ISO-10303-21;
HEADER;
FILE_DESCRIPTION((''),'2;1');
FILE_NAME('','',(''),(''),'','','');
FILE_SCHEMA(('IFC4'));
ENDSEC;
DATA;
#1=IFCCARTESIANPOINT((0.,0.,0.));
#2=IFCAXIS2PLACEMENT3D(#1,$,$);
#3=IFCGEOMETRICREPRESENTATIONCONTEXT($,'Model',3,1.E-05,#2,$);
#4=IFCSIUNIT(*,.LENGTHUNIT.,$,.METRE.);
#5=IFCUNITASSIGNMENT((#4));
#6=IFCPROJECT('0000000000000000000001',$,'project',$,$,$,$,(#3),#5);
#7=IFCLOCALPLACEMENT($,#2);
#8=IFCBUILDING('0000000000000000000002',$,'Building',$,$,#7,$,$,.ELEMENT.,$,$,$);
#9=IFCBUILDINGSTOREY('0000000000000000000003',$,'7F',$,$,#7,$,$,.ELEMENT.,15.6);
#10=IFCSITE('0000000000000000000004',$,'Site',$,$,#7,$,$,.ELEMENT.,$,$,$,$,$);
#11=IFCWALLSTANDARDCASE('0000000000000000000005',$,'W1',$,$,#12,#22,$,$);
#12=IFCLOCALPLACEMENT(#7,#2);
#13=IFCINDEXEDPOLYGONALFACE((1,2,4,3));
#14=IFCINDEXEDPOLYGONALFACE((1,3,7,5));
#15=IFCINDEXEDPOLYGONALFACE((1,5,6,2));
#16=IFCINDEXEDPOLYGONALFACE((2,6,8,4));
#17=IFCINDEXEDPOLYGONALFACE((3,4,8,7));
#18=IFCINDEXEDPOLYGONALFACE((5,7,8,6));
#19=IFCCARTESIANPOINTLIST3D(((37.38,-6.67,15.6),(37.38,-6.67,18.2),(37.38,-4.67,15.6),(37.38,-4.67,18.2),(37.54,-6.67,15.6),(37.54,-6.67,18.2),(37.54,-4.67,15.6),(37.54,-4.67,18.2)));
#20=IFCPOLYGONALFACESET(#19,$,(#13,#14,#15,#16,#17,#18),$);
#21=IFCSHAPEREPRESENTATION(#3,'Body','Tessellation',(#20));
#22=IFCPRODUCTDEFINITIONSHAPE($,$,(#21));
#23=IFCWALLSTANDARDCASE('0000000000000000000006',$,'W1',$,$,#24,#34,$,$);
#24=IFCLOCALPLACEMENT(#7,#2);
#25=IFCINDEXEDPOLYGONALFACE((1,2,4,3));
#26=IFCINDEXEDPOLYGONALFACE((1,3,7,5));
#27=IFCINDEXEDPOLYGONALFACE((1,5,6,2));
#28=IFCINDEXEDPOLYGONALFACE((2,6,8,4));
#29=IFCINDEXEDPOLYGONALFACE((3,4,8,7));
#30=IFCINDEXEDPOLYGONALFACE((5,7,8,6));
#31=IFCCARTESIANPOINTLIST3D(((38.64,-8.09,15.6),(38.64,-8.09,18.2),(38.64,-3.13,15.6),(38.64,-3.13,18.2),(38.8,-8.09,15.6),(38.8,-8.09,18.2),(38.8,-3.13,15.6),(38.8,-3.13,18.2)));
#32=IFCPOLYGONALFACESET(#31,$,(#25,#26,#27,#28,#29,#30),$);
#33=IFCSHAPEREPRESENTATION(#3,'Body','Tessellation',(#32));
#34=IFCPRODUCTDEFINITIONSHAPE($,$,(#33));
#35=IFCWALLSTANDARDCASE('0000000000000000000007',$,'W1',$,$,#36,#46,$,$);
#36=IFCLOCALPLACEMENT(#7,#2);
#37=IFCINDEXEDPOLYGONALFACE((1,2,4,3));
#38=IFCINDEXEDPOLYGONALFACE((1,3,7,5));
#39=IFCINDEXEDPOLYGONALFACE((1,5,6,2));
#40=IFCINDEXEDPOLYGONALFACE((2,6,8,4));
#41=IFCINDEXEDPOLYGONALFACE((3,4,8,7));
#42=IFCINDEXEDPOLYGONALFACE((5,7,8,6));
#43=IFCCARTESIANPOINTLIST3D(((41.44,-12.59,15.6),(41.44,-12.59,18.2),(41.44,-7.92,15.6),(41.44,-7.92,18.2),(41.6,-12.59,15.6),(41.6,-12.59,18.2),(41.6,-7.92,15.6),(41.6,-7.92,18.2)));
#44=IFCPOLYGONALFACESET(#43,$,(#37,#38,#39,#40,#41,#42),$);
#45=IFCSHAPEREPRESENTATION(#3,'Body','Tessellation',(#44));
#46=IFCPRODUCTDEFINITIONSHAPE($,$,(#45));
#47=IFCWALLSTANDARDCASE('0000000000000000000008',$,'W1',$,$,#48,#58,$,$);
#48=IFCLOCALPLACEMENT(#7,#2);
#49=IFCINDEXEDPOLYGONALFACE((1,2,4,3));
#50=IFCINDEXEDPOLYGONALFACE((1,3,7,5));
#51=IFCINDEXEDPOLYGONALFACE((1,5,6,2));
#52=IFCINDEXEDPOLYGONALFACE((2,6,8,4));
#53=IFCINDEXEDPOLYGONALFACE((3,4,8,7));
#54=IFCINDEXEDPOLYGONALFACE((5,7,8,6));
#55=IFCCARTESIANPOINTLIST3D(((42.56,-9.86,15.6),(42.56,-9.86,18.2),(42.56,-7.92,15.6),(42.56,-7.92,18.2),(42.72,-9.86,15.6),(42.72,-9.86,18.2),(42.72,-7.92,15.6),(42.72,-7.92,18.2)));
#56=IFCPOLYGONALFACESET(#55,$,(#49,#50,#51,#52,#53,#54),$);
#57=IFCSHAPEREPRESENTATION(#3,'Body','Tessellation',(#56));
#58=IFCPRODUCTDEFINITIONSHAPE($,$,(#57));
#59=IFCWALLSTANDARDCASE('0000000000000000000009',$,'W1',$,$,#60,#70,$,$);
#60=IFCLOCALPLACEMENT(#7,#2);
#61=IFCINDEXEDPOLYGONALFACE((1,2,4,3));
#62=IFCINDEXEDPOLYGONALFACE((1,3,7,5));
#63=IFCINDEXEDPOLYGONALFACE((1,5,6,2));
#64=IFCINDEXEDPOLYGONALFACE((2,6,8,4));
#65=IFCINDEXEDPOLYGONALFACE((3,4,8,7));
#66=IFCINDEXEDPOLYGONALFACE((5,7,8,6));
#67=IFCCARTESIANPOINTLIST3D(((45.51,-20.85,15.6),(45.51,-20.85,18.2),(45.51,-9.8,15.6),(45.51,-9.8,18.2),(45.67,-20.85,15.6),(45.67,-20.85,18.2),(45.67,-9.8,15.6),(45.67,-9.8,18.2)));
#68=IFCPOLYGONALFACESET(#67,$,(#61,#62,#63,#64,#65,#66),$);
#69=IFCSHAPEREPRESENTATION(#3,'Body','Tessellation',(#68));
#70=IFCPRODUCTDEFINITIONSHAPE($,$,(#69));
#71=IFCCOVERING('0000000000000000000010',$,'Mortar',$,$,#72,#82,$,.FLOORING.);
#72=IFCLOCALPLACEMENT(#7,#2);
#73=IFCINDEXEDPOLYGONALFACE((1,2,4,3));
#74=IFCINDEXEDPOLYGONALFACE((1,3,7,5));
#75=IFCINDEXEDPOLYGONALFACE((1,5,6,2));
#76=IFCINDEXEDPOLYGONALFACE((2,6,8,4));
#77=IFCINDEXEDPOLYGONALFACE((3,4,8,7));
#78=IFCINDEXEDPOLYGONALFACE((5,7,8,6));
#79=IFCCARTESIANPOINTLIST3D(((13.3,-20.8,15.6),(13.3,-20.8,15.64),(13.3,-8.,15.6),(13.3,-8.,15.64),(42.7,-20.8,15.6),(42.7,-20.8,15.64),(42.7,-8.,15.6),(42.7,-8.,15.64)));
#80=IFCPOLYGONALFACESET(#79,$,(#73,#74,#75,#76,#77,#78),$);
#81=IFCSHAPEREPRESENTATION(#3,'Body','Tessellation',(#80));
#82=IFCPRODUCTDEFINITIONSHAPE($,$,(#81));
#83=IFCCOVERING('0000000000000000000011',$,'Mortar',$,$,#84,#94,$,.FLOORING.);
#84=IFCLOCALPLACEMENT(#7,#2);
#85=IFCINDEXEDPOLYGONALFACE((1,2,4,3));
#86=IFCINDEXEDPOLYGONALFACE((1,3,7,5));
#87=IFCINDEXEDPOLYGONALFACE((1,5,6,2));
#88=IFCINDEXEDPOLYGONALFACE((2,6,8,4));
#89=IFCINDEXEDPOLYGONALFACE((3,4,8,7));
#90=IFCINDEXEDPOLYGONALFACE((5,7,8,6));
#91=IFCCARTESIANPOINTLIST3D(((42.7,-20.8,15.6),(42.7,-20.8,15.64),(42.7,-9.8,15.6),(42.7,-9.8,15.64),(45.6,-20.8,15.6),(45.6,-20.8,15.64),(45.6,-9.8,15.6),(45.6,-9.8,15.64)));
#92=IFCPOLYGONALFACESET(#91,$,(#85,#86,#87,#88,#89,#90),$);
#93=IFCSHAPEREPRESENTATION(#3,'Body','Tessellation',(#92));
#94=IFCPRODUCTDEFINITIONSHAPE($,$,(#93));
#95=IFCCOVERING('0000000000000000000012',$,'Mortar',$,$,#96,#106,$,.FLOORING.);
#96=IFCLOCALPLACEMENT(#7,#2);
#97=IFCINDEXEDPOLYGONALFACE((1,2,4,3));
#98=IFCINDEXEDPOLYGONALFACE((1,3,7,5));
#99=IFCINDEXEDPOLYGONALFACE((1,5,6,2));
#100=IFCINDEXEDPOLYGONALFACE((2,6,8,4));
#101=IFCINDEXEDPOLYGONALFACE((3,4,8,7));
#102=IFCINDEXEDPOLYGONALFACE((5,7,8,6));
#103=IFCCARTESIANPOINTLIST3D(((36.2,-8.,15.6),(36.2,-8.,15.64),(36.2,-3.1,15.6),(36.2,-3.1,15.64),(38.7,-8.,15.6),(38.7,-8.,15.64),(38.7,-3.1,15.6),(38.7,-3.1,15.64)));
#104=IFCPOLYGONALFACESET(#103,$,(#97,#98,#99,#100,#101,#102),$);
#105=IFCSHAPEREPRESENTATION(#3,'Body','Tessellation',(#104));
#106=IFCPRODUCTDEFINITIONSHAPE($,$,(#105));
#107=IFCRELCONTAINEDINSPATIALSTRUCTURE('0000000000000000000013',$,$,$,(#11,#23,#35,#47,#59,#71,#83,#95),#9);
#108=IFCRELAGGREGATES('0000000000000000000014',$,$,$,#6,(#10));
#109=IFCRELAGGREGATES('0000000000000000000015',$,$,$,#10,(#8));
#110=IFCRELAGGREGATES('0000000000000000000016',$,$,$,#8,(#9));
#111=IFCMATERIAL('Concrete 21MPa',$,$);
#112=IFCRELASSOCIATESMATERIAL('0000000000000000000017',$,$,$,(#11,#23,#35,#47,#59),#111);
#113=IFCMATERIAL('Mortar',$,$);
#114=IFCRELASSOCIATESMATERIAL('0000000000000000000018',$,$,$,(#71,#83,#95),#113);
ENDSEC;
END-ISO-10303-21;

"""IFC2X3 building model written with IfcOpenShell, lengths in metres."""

from ifc_helpers import new_model, si_unit, frame, origin, origin_2d, place, context, project, spatial, rectangle, extrude, material, element, save


model = new_model("IFC2X3")

# Units and contexts
model_context = context("Model", 3, precision=1e-05, world=origin())
ifc_project = project(units=[si_unit("LENGTHUNIT", "METRE")], contexts=[model_context])

# Site, building, storey
placement = place(None, origin())
site = spatial("IfcSite", under=ifc_project, at=placement, Name="Site", CompositionType="ELEMENT")
building = spatial("IfcBuilding", under=site, at=placement, Name="Building", CompositionType="ELEMENT")
storey = spatial("IfcBuildingStorey", under=building, at=placement, Name="7F", CompositionType="ELEMENT", Elevation=15.6)

# Shared definitions
ifc_material_1 = material(Name="Concrete 21MPa")

# Walls
wall_1_placement = place(None, frame((37.46, -5.67, 15.6)))
element("IfcWallStandardCase", 1, at=wall_1_placement, inside=storey, material=ifc_material_1, Name="W1", context=model_context, shape_type="SweptSolid", body=[
    extrude(rectangle(XDim=0.16, YDim=2.0, at=origin_2d()), origin(), (0.0, 0.0, 1.0), 2.6),
])
wall_2_placement = place(None, frame((38.72, -5.61, 15.6)))
element("IfcWallStandardCase", 2, at=wall_2_placement, inside=storey, material=ifc_material_1, Name="W1", context=model_context, shape_type="SweptSolid", body=[
    extrude(rectangle(XDim=0.16, YDim=4.96, at=origin_2d()), origin(), (0.0, 0.0, 1.0), 2.6),
])
wall_3_placement = place(None, frame((41.52, -10.255, 15.6)))
element("IfcWallStandardCase", 3, at=wall_3_placement, inside=storey, material=ifc_material_1, Name="W1", context=model_context, shape_type="SweptSolid", body=[
    extrude(rectangle(XDim=0.16, YDim=4.67, at=origin_2d()), origin(), (0.0, 0.0, 1.0), 2.6),
])
wall_4_placement = place(None, frame((42.64, -8.89, 15.6)))
element("IfcWallStandardCase", 4, at=wall_4_placement, inside=storey, material=ifc_material_1, Name="W1", context=model_context, shape_type="SweptSolid", body=[
    extrude(rectangle(XDim=0.16, YDim=1.94, at=origin_2d()), origin(), (0.0, 0.0, 1.0), 2.6),
])
wall_5_placement = place(None, frame((45.59, -15.325, 15.6)))
element("IfcWallStandardCase", 5, at=wall_5_placement, inside=storey, material=ifc_material_1, Name="W1", context=model_context, shape_type="SweptSolid", body=[
    extrude(rectangle(XDim=0.16, YDim=11.05, at=origin_2d()), origin(), (0.0, 0.0, 1.0), 2.6),
])

# Coverings
ifc_material_2 = material(Name="Mortar")
covering_1_placement = place(None, frame((28.0, -14.4, 15.6)))
element("IfcCovering", 6, at=covering_1_placement, inside=storey, material=ifc_material_2, Name="Mortar", PredefinedType="FLOORING", context=model_context, shape_type="SweptSolid", body=[
    extrude(rectangle(XDim=29.4, YDim=12.8, at=origin_2d()), origin(), (0.0, 0.0, 1.0), 0.04),
])
covering_2_placement = place(None, frame((44.15, -15.3, 15.6)))
element("IfcCovering", 7, at=covering_2_placement, inside=storey, material=ifc_material_2, Name="Mortar", PredefinedType="FLOORING", context=model_context, shape_type="SweptSolid", body=[
    extrude(rectangle(XDim=2.9, YDim=11.0, at=origin_2d()), origin(), (0.0, 0.0, 1.0), 0.04),
])
covering_3_placement = place(None, frame((37.45, -5.55, 15.6)))
element("IfcCovering", 8, at=covering_3_placement, inside=storey, material=ifc_material_2, Name="Mortar", PredefinedType="FLOORING", context=model_context, shape_type="SweptSolid", body=[
    extrude(rectangle(XDim=2.5, YDim=4.9, at=origin_2d()), origin(), (0.0, 0.0, 1.0), 0.04),
])

save(model, "model.ifc")
